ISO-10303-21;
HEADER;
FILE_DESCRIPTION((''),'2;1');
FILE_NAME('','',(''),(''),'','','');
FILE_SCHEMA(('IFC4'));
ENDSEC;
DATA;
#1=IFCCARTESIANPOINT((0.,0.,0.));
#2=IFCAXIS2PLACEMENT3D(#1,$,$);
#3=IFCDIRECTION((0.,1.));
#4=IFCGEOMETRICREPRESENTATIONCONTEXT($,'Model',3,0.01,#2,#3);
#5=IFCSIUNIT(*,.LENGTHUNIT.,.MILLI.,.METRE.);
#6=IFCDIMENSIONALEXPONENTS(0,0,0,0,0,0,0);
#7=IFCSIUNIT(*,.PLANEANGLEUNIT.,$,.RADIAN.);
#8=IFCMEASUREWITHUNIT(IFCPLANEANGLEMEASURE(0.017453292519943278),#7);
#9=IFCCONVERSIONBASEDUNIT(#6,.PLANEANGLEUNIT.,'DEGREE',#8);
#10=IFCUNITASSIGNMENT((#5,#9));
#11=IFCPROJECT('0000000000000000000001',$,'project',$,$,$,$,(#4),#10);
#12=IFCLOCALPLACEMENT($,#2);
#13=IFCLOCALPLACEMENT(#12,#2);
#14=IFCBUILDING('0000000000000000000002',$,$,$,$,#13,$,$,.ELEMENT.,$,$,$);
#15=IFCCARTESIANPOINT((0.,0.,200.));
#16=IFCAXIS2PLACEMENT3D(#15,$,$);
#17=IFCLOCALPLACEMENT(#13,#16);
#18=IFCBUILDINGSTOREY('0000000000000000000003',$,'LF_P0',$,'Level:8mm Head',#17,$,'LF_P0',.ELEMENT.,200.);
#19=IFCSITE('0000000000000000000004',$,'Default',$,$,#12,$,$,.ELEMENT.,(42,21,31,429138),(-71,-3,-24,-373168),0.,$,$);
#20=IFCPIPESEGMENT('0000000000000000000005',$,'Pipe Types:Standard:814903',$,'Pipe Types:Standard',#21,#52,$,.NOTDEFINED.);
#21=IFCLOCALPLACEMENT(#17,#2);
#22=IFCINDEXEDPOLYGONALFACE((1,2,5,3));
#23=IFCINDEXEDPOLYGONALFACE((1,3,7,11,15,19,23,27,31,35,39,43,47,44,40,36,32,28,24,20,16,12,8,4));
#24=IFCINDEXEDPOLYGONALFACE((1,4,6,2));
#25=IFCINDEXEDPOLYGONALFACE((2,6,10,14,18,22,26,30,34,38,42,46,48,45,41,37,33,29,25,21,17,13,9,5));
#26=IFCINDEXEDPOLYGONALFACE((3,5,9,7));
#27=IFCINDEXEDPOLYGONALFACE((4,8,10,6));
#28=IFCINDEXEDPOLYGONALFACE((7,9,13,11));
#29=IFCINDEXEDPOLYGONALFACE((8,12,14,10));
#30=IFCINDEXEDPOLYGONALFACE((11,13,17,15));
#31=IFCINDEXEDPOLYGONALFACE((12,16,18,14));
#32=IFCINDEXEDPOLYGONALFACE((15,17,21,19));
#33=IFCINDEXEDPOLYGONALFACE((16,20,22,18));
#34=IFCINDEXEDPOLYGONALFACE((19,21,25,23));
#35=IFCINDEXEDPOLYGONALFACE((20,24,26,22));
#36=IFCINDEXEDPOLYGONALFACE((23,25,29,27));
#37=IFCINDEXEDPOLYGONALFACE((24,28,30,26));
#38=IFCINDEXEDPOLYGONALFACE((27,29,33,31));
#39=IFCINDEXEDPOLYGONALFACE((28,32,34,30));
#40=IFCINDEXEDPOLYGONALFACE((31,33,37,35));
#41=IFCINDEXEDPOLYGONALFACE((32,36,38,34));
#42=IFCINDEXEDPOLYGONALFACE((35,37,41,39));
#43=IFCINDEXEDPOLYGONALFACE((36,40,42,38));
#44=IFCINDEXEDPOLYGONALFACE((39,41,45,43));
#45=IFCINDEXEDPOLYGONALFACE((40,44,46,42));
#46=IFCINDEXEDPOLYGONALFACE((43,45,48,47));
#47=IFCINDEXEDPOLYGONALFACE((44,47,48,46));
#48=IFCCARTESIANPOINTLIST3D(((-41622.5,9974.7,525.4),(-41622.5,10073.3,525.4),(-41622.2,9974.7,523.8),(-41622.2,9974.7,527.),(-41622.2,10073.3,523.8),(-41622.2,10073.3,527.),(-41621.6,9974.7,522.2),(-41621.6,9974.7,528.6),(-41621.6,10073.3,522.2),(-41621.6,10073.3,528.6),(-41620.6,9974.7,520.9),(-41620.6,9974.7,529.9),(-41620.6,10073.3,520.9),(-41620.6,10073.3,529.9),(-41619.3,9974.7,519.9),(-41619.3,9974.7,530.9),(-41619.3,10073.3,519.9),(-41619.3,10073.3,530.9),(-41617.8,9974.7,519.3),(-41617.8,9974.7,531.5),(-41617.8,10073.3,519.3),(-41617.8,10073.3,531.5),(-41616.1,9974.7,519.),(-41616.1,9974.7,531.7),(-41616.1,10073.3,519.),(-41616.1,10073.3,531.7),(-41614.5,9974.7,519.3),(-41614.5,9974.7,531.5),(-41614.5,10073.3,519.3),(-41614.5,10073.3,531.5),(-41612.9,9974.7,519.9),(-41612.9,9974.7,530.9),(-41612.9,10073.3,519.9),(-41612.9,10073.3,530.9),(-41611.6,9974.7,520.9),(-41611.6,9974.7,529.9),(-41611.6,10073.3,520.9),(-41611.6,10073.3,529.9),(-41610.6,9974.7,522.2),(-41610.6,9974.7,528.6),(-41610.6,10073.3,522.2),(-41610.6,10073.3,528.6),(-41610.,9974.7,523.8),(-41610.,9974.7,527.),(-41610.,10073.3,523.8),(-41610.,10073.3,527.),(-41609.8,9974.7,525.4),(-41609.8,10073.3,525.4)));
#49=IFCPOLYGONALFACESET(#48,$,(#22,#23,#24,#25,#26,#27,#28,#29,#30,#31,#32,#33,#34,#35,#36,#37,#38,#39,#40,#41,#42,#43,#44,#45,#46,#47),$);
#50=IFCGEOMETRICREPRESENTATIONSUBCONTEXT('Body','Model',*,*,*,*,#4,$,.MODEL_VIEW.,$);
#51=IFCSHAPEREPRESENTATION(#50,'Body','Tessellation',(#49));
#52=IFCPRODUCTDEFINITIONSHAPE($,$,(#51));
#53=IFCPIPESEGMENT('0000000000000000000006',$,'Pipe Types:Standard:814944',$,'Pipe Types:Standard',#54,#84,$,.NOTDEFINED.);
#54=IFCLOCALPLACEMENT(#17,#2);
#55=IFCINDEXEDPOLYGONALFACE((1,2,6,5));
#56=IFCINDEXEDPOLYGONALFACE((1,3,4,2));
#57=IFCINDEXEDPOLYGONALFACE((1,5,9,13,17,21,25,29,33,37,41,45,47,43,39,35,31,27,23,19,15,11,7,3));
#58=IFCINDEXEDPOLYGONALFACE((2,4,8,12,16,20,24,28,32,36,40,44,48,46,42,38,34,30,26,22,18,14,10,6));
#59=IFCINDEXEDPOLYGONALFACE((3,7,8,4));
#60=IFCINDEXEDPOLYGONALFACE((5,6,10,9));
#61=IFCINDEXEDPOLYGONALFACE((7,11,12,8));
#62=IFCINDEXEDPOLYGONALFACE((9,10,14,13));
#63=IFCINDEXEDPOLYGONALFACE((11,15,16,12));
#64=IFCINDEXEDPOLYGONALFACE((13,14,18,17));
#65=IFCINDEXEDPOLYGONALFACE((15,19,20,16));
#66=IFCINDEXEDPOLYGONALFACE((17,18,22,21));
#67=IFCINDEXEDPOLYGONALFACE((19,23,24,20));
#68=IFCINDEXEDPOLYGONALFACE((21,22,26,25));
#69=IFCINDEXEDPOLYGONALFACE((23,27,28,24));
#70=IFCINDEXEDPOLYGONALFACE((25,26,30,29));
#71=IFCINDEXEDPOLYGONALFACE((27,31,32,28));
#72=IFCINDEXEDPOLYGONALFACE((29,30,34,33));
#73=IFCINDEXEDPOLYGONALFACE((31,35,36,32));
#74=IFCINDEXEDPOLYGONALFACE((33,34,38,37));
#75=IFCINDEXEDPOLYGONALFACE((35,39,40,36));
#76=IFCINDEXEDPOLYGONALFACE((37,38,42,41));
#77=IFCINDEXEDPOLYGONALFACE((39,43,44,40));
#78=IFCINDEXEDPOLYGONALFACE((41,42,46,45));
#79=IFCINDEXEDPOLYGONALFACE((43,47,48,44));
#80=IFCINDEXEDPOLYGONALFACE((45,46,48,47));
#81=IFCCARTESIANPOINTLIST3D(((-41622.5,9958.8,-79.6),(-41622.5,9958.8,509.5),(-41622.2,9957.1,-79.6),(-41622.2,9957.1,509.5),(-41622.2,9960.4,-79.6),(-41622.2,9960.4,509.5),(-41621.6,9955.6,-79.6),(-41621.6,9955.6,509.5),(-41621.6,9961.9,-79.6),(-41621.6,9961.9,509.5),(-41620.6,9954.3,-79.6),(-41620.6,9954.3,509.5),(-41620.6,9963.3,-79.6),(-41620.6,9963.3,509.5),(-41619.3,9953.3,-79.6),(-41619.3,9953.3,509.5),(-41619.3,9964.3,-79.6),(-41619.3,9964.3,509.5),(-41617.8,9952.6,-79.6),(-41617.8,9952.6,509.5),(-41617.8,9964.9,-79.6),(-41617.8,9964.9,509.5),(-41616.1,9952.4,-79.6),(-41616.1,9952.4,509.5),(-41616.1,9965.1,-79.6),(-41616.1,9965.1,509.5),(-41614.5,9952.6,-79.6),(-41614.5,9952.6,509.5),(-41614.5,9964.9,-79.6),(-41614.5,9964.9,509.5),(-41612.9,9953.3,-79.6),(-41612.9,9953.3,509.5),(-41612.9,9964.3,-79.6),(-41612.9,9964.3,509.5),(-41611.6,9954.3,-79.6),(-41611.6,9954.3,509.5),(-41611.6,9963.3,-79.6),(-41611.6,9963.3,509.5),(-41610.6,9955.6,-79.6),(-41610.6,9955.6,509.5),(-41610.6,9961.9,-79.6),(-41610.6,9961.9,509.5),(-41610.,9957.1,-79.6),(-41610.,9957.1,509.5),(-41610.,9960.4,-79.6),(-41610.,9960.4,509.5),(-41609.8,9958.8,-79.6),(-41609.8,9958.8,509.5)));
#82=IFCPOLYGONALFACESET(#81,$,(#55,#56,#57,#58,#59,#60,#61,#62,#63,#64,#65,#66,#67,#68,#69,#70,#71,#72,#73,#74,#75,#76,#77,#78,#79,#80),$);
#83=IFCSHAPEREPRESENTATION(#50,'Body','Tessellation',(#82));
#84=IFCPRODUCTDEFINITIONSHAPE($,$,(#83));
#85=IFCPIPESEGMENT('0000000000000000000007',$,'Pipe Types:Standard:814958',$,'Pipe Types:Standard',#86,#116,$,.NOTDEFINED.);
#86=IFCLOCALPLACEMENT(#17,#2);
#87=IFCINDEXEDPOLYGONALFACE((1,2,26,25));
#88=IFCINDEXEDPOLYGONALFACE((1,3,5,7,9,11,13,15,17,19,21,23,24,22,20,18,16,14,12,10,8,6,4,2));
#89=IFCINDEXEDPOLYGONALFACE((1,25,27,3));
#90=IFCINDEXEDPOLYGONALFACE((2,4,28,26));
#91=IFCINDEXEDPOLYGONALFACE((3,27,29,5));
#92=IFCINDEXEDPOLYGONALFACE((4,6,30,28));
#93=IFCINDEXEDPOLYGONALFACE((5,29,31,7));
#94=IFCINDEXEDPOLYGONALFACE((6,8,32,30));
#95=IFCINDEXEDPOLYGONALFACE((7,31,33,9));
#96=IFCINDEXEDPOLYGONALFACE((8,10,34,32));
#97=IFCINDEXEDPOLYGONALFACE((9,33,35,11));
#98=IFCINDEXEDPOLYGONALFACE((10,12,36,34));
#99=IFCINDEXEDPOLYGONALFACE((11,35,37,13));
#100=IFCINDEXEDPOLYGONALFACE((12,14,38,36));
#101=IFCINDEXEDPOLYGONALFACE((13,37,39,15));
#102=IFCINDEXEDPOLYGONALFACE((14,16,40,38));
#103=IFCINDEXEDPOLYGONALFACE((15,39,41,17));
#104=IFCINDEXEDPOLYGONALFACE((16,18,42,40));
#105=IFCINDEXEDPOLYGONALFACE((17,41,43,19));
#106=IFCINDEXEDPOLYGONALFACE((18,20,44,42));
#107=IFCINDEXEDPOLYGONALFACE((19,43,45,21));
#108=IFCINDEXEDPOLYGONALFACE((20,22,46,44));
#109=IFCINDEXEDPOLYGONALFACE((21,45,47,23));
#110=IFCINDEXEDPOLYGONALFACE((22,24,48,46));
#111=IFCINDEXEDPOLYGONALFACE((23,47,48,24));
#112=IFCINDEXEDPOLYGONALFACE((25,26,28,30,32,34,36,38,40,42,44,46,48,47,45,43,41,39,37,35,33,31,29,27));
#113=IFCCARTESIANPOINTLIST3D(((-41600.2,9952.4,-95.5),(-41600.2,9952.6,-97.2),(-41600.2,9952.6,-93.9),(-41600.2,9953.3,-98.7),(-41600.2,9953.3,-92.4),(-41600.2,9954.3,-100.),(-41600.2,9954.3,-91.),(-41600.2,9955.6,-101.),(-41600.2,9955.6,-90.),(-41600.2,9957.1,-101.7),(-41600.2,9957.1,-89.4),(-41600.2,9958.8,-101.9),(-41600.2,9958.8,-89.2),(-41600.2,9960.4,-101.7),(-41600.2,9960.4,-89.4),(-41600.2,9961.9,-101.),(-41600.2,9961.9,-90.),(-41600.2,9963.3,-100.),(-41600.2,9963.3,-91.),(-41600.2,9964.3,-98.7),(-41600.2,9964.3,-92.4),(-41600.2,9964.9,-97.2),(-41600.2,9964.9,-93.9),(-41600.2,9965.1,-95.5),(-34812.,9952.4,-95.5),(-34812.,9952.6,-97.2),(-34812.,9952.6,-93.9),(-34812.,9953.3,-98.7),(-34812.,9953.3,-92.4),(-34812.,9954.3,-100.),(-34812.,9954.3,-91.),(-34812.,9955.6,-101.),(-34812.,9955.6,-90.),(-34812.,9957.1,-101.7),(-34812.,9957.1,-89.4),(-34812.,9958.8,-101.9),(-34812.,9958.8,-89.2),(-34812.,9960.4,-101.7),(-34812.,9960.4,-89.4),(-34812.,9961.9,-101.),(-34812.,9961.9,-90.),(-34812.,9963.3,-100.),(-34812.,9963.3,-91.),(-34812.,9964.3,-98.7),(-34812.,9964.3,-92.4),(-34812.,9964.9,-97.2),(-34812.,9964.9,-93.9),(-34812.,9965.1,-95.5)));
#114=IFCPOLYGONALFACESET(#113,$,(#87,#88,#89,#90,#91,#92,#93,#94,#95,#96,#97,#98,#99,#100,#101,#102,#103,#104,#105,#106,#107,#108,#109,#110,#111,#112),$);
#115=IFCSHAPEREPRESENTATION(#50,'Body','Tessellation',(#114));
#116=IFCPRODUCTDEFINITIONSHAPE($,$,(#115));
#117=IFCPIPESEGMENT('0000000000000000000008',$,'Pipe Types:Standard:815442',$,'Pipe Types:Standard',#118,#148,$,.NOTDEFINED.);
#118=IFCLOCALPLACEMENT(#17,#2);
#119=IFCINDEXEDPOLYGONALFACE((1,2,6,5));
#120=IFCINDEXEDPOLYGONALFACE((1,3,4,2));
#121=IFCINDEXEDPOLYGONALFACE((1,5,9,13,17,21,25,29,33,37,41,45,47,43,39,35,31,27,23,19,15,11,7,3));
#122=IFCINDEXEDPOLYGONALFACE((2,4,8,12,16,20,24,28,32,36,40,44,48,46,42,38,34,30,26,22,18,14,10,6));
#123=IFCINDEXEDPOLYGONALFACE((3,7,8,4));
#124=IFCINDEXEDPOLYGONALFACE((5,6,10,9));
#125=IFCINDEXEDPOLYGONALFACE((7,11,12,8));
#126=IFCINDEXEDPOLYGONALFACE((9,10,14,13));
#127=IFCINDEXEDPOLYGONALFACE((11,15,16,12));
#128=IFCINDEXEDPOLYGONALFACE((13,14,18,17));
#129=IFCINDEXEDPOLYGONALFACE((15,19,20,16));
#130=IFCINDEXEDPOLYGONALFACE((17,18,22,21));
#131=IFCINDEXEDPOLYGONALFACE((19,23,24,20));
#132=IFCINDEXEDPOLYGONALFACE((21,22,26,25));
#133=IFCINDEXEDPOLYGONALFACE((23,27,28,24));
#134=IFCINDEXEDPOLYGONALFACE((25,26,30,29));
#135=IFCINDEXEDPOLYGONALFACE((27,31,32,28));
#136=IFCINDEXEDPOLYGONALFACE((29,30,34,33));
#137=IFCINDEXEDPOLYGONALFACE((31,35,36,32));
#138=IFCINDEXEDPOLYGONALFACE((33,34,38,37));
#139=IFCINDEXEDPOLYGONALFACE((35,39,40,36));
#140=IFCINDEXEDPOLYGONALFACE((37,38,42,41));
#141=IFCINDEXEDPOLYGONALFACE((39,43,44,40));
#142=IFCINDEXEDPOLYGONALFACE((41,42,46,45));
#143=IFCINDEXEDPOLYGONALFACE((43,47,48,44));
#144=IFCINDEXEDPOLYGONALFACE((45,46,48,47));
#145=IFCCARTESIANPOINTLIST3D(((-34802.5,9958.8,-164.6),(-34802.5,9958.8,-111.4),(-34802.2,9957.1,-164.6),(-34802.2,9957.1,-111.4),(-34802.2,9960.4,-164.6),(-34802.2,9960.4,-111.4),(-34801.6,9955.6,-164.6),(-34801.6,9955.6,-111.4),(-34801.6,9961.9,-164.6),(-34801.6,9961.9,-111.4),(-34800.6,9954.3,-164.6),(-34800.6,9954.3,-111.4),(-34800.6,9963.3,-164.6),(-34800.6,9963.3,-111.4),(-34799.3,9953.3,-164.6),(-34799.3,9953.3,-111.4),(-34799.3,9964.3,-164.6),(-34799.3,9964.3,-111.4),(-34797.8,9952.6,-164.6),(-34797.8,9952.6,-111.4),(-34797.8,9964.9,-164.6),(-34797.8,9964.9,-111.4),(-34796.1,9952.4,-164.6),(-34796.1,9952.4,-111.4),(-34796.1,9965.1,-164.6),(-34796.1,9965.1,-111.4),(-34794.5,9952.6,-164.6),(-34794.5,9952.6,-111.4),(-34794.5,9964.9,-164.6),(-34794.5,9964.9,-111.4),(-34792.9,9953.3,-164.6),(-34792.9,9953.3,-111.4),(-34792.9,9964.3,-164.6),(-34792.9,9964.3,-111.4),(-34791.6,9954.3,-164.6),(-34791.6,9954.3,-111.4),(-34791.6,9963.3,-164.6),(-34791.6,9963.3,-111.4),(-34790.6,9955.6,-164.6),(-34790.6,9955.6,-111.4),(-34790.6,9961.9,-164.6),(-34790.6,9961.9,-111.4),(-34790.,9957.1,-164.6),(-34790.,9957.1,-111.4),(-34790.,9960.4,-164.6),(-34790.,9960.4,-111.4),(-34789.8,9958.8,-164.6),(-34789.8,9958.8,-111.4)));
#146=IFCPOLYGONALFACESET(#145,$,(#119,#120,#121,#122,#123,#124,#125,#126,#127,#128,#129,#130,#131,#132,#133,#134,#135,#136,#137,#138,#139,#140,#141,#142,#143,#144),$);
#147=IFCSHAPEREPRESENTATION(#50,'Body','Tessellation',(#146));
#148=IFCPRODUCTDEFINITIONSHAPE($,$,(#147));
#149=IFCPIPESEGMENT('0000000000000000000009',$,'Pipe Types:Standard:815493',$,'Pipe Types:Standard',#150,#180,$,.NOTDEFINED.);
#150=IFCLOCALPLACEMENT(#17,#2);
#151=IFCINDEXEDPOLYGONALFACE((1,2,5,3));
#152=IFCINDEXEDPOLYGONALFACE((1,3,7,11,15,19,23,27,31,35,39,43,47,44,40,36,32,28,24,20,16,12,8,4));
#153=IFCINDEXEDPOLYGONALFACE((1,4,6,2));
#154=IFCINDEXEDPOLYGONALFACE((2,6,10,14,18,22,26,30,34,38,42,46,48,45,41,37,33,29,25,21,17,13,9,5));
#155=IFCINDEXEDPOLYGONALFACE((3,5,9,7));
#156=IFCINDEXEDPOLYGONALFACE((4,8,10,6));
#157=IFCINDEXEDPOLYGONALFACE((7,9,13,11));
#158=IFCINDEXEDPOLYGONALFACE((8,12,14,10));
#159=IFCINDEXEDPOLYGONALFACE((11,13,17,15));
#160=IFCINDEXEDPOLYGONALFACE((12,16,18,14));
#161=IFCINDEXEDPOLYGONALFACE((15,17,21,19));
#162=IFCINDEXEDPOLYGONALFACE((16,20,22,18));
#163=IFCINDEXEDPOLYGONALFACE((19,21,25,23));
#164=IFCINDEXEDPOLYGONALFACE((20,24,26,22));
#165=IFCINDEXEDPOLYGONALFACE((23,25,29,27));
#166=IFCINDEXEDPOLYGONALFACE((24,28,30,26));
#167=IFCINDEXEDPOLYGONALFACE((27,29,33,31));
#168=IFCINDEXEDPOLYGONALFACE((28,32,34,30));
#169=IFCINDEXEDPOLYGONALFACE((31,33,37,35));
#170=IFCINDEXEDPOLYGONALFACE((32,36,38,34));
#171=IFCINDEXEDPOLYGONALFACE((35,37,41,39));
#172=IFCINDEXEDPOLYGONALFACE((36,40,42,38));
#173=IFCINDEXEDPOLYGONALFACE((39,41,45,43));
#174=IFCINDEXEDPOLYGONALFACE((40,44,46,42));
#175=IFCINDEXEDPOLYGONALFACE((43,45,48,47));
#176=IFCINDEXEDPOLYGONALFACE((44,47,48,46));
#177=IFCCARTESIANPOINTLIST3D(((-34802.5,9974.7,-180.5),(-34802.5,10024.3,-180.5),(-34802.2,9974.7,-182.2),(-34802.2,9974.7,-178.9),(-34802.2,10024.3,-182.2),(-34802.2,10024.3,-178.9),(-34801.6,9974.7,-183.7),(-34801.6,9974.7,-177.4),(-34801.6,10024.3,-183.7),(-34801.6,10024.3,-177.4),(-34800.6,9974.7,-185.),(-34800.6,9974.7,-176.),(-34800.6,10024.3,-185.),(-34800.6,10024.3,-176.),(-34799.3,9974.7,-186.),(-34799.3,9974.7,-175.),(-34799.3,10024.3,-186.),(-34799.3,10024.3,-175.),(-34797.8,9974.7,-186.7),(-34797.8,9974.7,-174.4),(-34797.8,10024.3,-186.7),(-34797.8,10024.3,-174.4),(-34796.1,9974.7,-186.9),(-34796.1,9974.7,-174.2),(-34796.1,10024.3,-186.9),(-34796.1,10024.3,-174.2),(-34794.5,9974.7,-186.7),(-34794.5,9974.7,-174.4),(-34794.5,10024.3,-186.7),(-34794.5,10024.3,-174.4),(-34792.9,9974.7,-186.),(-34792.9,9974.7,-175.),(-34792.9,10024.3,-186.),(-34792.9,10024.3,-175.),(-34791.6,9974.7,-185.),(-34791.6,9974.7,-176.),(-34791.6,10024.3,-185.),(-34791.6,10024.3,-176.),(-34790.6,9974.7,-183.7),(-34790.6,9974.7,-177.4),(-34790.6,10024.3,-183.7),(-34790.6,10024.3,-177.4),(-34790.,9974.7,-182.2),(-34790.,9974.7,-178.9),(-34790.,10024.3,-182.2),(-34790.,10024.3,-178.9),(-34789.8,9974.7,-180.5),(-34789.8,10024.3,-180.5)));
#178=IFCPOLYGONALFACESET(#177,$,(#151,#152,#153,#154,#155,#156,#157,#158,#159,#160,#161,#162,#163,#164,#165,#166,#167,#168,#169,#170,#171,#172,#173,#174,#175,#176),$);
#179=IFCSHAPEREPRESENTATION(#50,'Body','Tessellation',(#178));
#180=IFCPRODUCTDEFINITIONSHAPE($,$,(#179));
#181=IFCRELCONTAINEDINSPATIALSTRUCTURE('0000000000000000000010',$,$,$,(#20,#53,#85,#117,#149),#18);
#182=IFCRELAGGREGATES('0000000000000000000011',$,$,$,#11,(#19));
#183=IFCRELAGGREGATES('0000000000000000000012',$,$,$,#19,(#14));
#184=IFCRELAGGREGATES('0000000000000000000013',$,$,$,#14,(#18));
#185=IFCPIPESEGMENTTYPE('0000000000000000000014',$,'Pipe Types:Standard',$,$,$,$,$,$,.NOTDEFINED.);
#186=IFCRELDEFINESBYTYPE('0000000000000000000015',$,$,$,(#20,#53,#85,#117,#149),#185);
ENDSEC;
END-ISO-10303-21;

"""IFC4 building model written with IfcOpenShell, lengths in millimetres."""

from ifc_helpers import new_model, entity, si_unit, converted_unit, direction, frame, origin, place, context, subcontext, project, spatial, arc, indexed_curve, outline, extrude, type_object, element, save


model = new_model("IFC4")

# Units and contexts
model_context = context("Model", 3, precision=0.01, world=origin(), true_north=direction((0.0, 1.0)))
body_context = subcontext(model_context, "Body", "Model", "MODEL_VIEW")
ifc_project = project(units=[si_unit("LENGTHUNIT", "METRE", prefix="MILLI"), converted_unit("PLANEANGLEUNIT", "DEGREE", entity("IfcPlaneAngleMeasure", 0.017453292519943278), si_unit("PLANEANGLEUNIT", "RADIAN"), dimensions=[0, 0, 0, 0, 0, 0, 0])], contexts=[model_context])

# Site, building, storey
site_placement = place(None, origin())
site = spatial("IfcSite", under=ifc_project, at=site_placement, Name="Default", CompositionType="ELEMENT", RefLatitude=(42, 21, 31, 429138), RefLongitude=(-71, -3, -24, -373168), RefElevation=0.0)
building_placement = place(site_placement, origin())
building = spatial("IfcBuilding", under=site, at=building_placement, CompositionType="ELEMENT")
storey_placement = place(building_placement, frame((0.0, 0.0, 200.0)))
storey = spatial("IfcBuildingStorey", under=building, at=storey_placement, Name="LF_P0", ObjectType="Level:8mm Head", LongName="LF_P0", CompositionType="ELEMENT", Elevation=200.0)

# Pipe segments
pipe_segment_type = type_object("IfcPipeSegmentType", Name="Pipe Types:Standard", PredefinedType="NOTDEFINED")
pipe_segment_1_placement = place(storey_placement, origin())
element("IfcPipeSegment", 1, at=pipe_segment_1_placement, inside=storey, type_object=pipe_segment_type, Name="Pipe Types:Standard:814903", ObjectType="Pipe Types:Standard", PredefinedType="NOTDEFINED", context=body_context, shape_type="SweptSolid", body=[
    extrude(outline(indexed_curve([(6.4, 0.0), (4.5, 4.5), (0.0, 6.4), (-4.5, 4.5), (-6.4, 0.0), (-4.5, -4.5), (0.0, -6.4), (4.5, -4.5)], segments=[arc(1, 2, 3), arc(3, 4, 5), arc(5, 6, 7), arc(7, 8, 1)], self_intersect=False)), frame((-41616.1, 9974.7, 525.4), z_axis=(0.0, 1.0, 0.0), x_axis=(-1.0, 0.0, 0.0)), (0.0, 0.0, 1.0), 98.6),
])
pipe_segment_2_placement = place(storey_placement, origin())
element("IfcPipeSegment", 2, at=pipe_segment_2_placement, inside=storey, type_object=pipe_segment_type, Name="Pipe Types:Standard:814944", ObjectType="Pipe Types:Standard", PredefinedType="NOTDEFINED", context=body_context, shape_type="SweptSolid", body=[
    extrude(outline(indexed_curve([(6.4, 0.0), (4.5, 4.5), (0.0, 6.4), (-4.5, 4.5), (-6.4, 0.0), (-4.5, -4.5), (0.0, -6.4), (4.5, -4.5)], segments=[arc(1, 2, 3), arc(3, 4, 5), arc(5, 6, 7), arc(7, 8, 1)], self_intersect=False)), frame((-41616.1, 9958.8, -79.6)), (0.0, 0.0, 1.0), 589.1),
])
pipe_segment_3_placement = place(storey_placement, origin())
element("IfcPipeSegment", 3, at=pipe_segment_3_placement, inside=storey, type_object=pipe_segment_type, Name="Pipe Types:Standard:814958", ObjectType="Pipe Types:Standard", PredefinedType="NOTDEFINED", context=body_context, shape_type="SweptSolid", body=[
    extrude(outline(indexed_curve([(6.4, 0.0), (4.5, 4.5), (0.0, 6.3), (-4.5, 4.5), (-6.4, 0.0), (-4.5, -4.5), (0.0, -6.4), (4.5, -4.5)], segments=[arc(1, 2, 3), arc(3, 4, 5), arc(5, 6, 7), arc(7, 8, 1)], self_intersect=False)), frame((-41600.2, 9958.8, -95.5), z_axis=(1.0, 0.0, 0.0), x_axis=(0.0, -1.0, 0.0)), (0.0, 0.0, 1.0), 6788.2),
])
pipe_segment_4_placement = place(storey_placement, origin())
element("IfcPipeSegment", 4, at=pipe_segment_4_placement, inside=storey, type_object=pipe_segment_type, Name="Pipe Types:Standard:815442", ObjectType="Pipe Types:Standard", PredefinedType="NOTDEFINED", context=body_context, shape_type="SweptSolid", body=[
    extrude(outline(indexed_curve([(6.3, 0.0), (4.5, 4.5), (0.0, 6.4), (-4.5, 4.5), (-6.3, 0.0), (-4.5, -4.5), (0.0, -6.3), (4.5, -4.5)], segments=[arc(1, 2, 3), arc(3, 4, 5), arc(5, 6, 7), arc(7, 8, 1)], self_intersect=False)), frame((-34796.1, 9958.8, -164.6)), (0.0, 0.0, 1.0), 53.2),
])
pipe_segment_5_placement = place(storey_placement, origin())
element("IfcPipeSegment", 5, at=pipe_segment_5_placement, inside=storey, type_object=pipe_segment_type, Name="Pipe Types:Standard:815493", ObjectType="Pipe Types:Standard", PredefinedType="NOTDEFINED", context=body_context, shape_type="SweptSolid", body=[
    extrude(outline(indexed_curve([(6.4, 0.0), (4.5, 4.5), (0.0, 6.3), (-4.5, 4.5), (-6.3, 0.0), (-4.5, -4.5), (0.0, -6.4), (4.5, -4.5)], segments=[arc(1, 2, 3), arc(3, 4, 5), arc(5, 6, 7), arc(7, 8, 1)], self_intersect=False)), frame((-34796.1, 9974.7, -180.5), z_axis=(0.0, 1.0, 0.0), x_axis=(-1.0, 0.0, 0.0)), (0.0, 0.0, 1.0), 49.6),
])

save(model, "model.ifc")
